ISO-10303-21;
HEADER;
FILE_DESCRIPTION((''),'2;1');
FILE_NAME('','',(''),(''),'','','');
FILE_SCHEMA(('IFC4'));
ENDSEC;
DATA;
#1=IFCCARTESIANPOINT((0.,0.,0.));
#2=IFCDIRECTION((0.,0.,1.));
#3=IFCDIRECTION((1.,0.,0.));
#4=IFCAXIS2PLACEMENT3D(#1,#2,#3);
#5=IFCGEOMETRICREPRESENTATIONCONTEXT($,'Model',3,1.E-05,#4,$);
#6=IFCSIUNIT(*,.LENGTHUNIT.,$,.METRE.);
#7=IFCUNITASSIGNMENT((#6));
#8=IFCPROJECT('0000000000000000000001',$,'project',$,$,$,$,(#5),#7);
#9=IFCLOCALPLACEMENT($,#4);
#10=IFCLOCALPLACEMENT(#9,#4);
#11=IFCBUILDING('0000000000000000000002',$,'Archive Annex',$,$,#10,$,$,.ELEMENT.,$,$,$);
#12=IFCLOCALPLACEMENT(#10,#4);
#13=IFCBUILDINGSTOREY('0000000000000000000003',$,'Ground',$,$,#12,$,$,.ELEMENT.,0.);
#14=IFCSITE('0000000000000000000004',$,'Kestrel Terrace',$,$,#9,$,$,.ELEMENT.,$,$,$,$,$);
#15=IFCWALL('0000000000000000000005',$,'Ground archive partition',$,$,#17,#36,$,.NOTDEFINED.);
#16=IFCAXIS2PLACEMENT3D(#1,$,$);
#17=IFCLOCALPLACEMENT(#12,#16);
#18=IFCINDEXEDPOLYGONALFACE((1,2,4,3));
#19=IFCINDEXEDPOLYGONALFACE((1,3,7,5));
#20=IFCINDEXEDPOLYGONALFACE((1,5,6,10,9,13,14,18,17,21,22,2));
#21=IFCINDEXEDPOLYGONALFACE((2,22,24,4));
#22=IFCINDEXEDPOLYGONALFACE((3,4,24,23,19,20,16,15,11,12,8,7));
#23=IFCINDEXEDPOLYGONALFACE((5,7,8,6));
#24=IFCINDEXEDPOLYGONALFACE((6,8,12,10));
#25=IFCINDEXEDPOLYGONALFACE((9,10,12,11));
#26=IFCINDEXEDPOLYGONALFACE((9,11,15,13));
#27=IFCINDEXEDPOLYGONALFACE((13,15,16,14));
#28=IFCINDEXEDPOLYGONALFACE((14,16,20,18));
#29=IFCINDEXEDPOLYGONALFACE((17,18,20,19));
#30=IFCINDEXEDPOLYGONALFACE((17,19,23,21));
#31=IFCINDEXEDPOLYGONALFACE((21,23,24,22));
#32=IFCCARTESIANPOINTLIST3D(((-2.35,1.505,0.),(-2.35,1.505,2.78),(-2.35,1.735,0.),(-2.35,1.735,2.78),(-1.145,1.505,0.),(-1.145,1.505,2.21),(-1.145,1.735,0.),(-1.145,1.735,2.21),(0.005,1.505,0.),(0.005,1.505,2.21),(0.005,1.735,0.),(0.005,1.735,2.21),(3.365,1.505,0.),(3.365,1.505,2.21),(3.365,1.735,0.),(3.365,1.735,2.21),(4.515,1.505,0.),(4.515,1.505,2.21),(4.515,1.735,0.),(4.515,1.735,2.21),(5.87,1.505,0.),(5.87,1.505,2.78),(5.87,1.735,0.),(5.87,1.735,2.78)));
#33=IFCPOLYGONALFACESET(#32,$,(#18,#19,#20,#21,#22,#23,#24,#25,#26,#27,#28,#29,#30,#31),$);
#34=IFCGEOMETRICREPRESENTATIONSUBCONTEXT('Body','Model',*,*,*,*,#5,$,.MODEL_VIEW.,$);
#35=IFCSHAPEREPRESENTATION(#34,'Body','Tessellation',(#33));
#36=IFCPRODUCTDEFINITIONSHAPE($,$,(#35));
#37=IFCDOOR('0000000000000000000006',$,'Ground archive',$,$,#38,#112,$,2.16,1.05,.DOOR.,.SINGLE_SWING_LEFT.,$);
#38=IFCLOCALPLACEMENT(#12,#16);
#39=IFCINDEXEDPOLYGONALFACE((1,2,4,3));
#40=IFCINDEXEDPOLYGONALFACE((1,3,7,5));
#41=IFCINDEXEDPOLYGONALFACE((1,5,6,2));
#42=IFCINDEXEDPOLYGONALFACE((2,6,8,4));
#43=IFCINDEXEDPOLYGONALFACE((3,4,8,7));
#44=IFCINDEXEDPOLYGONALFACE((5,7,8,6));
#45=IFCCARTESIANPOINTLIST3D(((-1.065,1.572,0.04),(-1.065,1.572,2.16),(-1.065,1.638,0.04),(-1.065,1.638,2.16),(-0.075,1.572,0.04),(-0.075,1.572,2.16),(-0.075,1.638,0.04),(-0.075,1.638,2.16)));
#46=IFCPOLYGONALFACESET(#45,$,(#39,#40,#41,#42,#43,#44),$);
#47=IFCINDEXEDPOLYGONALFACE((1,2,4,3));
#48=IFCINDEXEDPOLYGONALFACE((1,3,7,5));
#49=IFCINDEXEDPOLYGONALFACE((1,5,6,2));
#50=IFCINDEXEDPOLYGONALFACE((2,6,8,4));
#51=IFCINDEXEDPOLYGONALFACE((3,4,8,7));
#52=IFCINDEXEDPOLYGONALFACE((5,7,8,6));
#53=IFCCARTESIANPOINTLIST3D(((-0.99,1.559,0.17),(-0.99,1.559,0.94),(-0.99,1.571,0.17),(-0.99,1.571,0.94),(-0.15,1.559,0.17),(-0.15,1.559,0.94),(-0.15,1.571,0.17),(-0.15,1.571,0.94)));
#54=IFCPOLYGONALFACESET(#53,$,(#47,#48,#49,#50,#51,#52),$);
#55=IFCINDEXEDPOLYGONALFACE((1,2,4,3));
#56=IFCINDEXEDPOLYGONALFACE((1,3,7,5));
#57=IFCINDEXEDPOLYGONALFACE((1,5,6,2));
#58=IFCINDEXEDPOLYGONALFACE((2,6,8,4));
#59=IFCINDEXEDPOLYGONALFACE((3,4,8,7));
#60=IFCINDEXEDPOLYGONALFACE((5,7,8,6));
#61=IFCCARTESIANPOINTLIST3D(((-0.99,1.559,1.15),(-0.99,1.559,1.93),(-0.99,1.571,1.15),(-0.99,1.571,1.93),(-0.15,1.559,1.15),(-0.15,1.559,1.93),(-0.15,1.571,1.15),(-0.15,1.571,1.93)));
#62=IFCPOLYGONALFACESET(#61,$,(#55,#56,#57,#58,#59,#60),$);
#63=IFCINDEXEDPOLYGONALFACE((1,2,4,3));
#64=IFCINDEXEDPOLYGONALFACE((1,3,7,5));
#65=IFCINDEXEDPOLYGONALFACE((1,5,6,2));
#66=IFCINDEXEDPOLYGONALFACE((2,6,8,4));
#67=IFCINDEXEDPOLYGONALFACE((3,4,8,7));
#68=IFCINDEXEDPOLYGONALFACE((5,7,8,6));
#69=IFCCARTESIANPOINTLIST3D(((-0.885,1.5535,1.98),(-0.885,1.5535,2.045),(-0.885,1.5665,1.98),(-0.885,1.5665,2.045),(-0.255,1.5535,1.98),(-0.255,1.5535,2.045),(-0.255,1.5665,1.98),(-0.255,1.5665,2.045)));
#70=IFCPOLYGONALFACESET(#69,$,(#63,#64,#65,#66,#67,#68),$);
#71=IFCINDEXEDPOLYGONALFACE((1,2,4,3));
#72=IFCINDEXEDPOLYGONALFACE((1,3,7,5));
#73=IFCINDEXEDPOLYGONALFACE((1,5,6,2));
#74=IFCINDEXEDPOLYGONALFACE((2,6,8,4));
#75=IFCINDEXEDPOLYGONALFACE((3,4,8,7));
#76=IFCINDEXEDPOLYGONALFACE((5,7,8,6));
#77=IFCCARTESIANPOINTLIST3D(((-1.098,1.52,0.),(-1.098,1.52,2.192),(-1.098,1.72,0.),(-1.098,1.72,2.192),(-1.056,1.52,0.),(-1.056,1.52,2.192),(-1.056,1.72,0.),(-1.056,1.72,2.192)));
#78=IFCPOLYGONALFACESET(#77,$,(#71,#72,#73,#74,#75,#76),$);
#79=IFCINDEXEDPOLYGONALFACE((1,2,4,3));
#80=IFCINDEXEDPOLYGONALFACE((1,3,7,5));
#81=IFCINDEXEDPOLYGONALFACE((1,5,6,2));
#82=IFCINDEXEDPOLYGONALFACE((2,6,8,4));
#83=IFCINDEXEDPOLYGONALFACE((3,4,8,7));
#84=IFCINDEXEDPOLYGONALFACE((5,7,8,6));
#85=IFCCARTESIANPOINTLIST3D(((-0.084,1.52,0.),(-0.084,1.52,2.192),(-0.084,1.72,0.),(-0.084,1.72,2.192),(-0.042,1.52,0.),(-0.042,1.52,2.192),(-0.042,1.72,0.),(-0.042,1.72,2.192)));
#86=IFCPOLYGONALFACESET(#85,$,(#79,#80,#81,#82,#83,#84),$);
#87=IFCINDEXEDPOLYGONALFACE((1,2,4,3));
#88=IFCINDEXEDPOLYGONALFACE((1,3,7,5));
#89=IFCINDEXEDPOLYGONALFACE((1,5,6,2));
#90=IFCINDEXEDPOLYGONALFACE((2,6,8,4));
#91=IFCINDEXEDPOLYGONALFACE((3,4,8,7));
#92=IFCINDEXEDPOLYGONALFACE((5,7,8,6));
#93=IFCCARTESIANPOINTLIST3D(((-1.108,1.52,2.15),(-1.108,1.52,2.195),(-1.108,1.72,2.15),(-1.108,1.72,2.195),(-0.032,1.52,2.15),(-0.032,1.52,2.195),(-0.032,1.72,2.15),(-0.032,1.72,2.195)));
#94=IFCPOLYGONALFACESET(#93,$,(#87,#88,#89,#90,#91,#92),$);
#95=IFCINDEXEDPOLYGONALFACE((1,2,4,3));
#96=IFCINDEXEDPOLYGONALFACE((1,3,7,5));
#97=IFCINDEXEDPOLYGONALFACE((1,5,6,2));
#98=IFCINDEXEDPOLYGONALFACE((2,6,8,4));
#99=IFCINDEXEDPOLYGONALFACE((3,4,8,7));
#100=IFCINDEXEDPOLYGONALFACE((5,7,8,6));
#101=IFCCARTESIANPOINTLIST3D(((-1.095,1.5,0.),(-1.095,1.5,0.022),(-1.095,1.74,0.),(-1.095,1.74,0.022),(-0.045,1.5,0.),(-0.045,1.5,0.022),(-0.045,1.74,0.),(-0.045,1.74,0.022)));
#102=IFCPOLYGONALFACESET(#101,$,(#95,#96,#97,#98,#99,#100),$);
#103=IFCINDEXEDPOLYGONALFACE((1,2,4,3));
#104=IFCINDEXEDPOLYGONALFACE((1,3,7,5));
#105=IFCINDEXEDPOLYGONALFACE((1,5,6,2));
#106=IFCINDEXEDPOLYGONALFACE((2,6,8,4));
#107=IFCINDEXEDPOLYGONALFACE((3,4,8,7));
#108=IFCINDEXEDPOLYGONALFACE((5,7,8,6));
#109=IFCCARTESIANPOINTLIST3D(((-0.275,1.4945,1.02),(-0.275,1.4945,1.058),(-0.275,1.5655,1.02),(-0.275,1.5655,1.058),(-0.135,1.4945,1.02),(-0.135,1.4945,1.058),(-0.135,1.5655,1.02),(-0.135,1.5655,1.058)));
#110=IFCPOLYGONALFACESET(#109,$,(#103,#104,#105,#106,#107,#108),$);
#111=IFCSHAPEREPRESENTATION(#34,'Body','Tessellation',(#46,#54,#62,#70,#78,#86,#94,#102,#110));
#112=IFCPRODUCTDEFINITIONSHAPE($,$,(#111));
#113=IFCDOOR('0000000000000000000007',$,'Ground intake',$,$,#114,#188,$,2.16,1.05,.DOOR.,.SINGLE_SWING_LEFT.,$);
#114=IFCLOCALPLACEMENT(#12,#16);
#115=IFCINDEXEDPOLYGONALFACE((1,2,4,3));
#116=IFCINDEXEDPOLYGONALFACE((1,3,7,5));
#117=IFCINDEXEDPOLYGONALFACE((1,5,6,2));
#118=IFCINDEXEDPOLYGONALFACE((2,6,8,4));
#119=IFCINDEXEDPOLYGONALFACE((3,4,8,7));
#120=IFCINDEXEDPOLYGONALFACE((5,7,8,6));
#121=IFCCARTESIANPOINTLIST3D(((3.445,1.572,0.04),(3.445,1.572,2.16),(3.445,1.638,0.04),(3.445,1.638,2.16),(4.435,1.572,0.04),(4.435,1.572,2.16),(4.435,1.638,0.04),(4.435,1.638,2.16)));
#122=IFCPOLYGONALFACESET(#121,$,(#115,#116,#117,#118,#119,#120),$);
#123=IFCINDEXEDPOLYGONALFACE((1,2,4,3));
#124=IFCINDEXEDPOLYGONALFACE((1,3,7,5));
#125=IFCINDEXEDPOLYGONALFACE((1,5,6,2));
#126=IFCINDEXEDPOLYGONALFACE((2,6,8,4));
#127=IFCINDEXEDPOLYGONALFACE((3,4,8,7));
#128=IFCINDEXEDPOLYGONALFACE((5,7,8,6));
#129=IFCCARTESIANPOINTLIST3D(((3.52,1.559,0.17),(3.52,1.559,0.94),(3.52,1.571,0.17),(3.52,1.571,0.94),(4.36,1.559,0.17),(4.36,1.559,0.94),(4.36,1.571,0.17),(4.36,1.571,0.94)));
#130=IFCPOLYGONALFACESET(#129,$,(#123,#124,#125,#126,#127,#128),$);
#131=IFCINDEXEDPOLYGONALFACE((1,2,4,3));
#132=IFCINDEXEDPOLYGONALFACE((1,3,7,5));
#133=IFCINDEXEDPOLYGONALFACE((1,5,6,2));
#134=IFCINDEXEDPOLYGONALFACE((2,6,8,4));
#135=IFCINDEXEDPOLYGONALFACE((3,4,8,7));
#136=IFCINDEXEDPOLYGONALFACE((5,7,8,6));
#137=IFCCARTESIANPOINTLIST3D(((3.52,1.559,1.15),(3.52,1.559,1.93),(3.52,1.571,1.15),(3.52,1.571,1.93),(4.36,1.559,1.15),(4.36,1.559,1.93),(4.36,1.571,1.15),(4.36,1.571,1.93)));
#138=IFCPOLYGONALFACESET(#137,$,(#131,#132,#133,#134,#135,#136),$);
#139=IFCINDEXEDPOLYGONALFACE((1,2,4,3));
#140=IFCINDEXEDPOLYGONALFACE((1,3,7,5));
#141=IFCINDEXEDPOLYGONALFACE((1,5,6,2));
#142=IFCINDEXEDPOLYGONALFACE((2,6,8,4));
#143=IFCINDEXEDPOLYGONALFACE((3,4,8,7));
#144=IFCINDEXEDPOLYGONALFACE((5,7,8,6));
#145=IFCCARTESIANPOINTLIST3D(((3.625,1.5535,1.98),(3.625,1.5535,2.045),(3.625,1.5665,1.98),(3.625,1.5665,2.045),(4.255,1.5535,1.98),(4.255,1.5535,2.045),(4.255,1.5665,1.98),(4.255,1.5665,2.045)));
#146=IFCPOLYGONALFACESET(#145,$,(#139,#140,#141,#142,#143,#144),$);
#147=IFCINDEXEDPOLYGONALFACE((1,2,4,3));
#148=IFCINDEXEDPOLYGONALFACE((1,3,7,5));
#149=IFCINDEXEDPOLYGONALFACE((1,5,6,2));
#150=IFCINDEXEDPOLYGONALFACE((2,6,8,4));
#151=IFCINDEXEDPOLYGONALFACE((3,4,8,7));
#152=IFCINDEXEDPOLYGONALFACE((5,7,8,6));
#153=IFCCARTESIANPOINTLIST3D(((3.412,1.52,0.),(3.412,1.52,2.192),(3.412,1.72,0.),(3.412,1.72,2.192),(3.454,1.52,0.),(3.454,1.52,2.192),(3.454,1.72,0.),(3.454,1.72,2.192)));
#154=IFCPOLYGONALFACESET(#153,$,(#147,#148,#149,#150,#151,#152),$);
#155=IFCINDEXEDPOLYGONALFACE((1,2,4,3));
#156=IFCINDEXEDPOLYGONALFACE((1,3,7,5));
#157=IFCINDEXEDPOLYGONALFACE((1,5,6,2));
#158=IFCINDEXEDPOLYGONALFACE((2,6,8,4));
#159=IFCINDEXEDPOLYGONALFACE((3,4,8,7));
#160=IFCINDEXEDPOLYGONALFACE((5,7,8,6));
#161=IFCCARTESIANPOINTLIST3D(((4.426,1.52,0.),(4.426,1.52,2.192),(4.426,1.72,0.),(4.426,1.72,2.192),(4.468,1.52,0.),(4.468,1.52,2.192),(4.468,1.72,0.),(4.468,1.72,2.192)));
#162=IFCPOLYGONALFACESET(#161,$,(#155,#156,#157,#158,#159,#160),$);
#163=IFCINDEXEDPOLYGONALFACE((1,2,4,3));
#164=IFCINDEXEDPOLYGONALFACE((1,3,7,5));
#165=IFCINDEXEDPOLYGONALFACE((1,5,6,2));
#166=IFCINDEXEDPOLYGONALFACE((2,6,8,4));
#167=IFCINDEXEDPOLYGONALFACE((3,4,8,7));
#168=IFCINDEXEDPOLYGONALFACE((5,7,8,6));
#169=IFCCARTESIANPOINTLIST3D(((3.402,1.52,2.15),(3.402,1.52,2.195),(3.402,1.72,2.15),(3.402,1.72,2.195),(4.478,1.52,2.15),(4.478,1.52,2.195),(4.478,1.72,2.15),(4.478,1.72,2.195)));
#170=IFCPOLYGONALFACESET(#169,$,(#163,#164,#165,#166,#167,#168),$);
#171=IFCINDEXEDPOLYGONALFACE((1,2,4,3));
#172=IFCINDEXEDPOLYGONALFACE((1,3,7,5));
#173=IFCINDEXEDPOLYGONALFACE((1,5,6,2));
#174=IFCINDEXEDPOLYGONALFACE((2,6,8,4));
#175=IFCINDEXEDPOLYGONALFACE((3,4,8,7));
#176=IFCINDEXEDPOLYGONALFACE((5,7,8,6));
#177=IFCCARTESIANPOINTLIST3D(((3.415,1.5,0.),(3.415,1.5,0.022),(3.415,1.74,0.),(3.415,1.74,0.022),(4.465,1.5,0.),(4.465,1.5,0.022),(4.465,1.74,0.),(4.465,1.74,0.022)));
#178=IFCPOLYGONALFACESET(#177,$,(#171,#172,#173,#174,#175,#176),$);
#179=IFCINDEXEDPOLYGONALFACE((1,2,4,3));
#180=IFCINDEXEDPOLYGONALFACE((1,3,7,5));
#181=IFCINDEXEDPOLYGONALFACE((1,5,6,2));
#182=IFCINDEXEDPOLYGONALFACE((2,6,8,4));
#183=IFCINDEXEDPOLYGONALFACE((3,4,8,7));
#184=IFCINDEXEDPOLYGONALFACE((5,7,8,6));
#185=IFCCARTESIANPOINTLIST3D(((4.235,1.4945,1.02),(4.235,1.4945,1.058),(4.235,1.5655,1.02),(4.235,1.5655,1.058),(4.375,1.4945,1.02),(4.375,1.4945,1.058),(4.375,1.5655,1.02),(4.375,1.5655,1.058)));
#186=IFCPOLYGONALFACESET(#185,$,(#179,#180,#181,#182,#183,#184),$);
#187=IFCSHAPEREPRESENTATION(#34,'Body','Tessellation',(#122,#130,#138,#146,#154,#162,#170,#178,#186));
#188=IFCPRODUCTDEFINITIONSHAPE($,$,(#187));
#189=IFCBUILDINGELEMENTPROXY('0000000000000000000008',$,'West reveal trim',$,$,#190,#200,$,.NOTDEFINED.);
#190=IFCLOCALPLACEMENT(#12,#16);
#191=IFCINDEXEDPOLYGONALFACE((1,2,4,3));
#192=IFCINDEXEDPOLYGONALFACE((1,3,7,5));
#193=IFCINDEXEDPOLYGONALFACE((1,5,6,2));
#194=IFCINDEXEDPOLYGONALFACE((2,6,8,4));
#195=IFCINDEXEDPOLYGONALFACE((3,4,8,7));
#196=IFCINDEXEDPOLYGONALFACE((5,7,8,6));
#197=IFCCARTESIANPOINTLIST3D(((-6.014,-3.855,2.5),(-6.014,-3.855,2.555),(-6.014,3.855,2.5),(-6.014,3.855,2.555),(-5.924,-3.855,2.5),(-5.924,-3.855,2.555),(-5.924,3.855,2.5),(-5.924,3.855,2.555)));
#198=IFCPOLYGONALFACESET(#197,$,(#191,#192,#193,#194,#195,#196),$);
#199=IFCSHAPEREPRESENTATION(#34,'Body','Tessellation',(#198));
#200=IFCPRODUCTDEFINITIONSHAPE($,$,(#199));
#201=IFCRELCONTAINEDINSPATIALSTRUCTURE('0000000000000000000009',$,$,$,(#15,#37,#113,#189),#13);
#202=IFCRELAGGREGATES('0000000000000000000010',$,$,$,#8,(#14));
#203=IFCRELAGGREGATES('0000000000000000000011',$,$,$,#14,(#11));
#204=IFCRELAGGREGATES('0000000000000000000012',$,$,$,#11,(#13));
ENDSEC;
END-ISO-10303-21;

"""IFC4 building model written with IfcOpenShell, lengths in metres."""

from ifc_helpers import new_model, si_unit, frame, origin_with_axes, origin_2d, place, context, subcontext, project, spatial, rectangle, extrude, element, fill, save


model = new_model("IFC4")

# Units and contexts
model_context = context("Model", 3, precision=1e-05, world=origin_with_axes())
body_context = subcontext(model_context, "Body", "Model", "MODEL_VIEW")
ifc_project = project(units=[si_unit("LENGTHUNIT", "METRE")], contexts=[model_context])

# Site, building, storey
site_placement = place(None, origin_with_axes())
site = spatial("IfcSite", under=ifc_project, at=site_placement, Name="Kestrel Terrace", CompositionType="ELEMENT")
building_placement = place(site_placement, origin_with_axes())
building = spatial("IfcBuilding", under=site, at=building_placement, Name="Archive Annex", CompositionType="ELEMENT")
storey_placement = place(building_placement, origin_with_axes())
storey = spatial("IfcBuildingStorey", under=building, at=storey_placement, Name="Ground", CompositionType="ELEMENT", Elevation=0.0)

# Wall, openings, doors
wall_1_placement = place(storey_placement, frame((1.76, 1.62, 0.0), z_axis=(0.0, 0.0, 1.0), x_axis=(1.0, 0.0, 0.0)))
wall_1 = element("IfcWall", 1, at=wall_1_placement, inside=storey, Name="Ground archive partition", PredefinedType="NOTDEFINED", context=body_context, shape_type="SweptSolid", body=[
    extrude(rectangle(XDim=8.22, YDim=0.23, at=origin_2d()), origin_with_axes(), (0.0, 0.0, 1.0), 2.78),
])
opening_1_placement = place(wall_1_placement, frame((-2.33, 0.0, 0.0), z_axis=(0.0, 0.0, 1.0), x_axis=(1.0, 0.0, 0.0)))
opening_1 = element("IfcOpeningElement", 2, at=opening_1_placement, cuts=wall_1, PredefinedType="OPENING", context=body_context, shape_type="SweptSolid", body=[
    extrude(rectangle(XDim=1.15, YDim=0.58, at=origin_2d()), origin_with_axes(), (0.0, 0.0, 1.0), 2.21),
])
opening_2_placement = place(wall_1_placement, frame((2.18, 0.0, 0.0), z_axis=(0.0, 0.0, 1.0), x_axis=(1.0, 0.0, 0.0)))
opening_2 = element("IfcOpeningElement", 3, at=opening_2_placement, cuts=wall_1, PredefinedType="OPENING", context=body_context, shape_type="SweptSolid", body=[
    extrude(rectangle(XDim=1.15, YDim=0.58, at=origin_2d()), origin_with_axes(), (0.0, 0.0, 1.0), 2.21),
])
door_1_placement = place(opening_1_placement, origin_with_axes())
door_1 = element("IfcDoor", 4, at=door_1_placement, inside=storey, Name="Ground archive", OperationType="SINGLE_SWING_LEFT", OverallHeight=2.16, OverallWidth=1.05, PredefinedType="DOOR", context=body_context, shape_type="SweptSolid", body=[
    extrude(rectangle(XDim=0.99, YDim=0.066, at=origin_2d()), frame((0.0, -0.015, 0.04), z_axis=(0.0, 0.0, 1.0), x_axis=(1.0, 0.0, 0.0)), (0.0, 0.0, 1.0), 2.12),
    extrude(rectangle(XDim=0.84, YDim=0.012, at=origin_2d()), frame((0.0, -0.055, 0.17), z_axis=(0.0, 0.0, 1.0), x_axis=(1.0, 0.0, 0.0)), (0.0, 0.0, 1.0), 0.77),
    extrude(rectangle(XDim=0.84, YDim=0.012, at=origin_2d()), frame((0.0, -0.055, 1.15), z_axis=(0.0, 0.0, 1.0), x_axis=(1.0, 0.0, 0.0)), (0.0, 0.0, 1.0), 0.78),
    extrude(rectangle(XDim=0.63, YDim=0.013, at=origin_2d()), frame((0.0, -0.06, 1.98), z_axis=(0.0, 0.0, 1.0), x_axis=(1.0, 0.0, 0.0)), (0.0, 0.0, 1.0), 0.065),
    extrude(rectangle(XDim=0.042, YDim=0.2, at=origin_2d()), frame((-0.507, 0.0, 0.0), z_axis=(0.0, 0.0, 1.0), x_axis=(1.0, 0.0, 0.0)), (0.0, 0.0, 1.0), 2.192),
    extrude(rectangle(XDim=0.042, YDim=0.2, at=origin_2d()), frame((0.507, 0.0, 0.0), z_axis=(0.0, 0.0, 1.0), x_axis=(1.0, 0.0, 0.0)), (0.0, 0.0, 1.0), 2.192),
    extrude(rectangle(XDim=1.076, YDim=0.2, at=origin_2d()), frame((0.0, 0.0, 2.15), z_axis=(0.0, 0.0, 1.0), x_axis=(1.0, 0.0, 0.0)), (0.0, 0.0, 1.0), 0.045),
    extrude(rectangle(XDim=1.05, YDim=0.24, at=origin_2d()), origin_with_axes(), (0.0, 0.0, 1.0), 0.022),
    extrude(rectangle(XDim=0.14, YDim=0.071, at=origin_2d()), frame((0.365, -0.09, 1.02), z_axis=(0.0, 0.0, 1.0), x_axis=(1.0, 0.0, 0.0)), (0.0, 0.0, 1.0), 0.038),
])
fill(opening_1, door_1)
door_2_placement = place(opening_2_placement, origin_with_axes())
door_2 = element("IfcDoor", 5, at=door_2_placement, inside=storey, Name="Ground intake", OperationType="SINGLE_SWING_LEFT", OverallHeight=2.16, OverallWidth=1.05, PredefinedType="DOOR", context=body_context, shape_type="SweptSolid", body=[
    extrude(rectangle(XDim=0.99, YDim=0.066, at=origin_2d()), frame((0.0, -0.015, 0.04), z_axis=(0.0, 0.0, 1.0), x_axis=(1.0, 0.0, 0.0)), (0.0, 0.0, 1.0), 2.12),
    extrude(rectangle(XDim=0.84, YDim=0.012, at=origin_2d()), frame((0.0, -0.055, 0.17), z_axis=(0.0, 0.0, 1.0), x_axis=(1.0, 0.0, 0.0)), (0.0, 0.0, 1.0), 0.77),
    extrude(rectangle(XDim=0.84, YDim=0.012, at=origin_2d()), frame((0.0, -0.055, 1.15), z_axis=(0.0, 0.0, 1.0), x_axis=(1.0, 0.0, 0.0)), (0.0, 0.0, 1.0), 0.78),
    extrude(rectangle(XDim=0.63, YDim=0.013, at=origin_2d()), frame((0.0, -0.06, 1.98), z_axis=(0.0, 0.0, 1.0), x_axis=(1.0, 0.0, 0.0)), (0.0, 0.0, 1.0), 0.065),
    extrude(rectangle(XDim=0.042, YDim=0.2, at=origin_2d()), frame((-0.507, 0.0, 0.0), z_axis=(0.0, 0.0, 1.0), x_axis=(1.0, 0.0, 0.0)), (0.0, 0.0, 1.0), 2.192),
    extrude(rectangle(XDim=0.042, YDim=0.2, at=origin_2d()), frame((0.507, 0.0, 0.0), z_axis=(0.0, 0.0, 1.0), x_axis=(1.0, 0.0, 0.0)), (0.0, 0.0, 1.0), 2.192),
    extrude(rectangle(XDim=1.076, YDim=0.2, at=origin_2d()), frame((0.0, 0.0, 2.15), z_axis=(0.0, 0.0, 1.0), x_axis=(1.0, 0.0, 0.0)), (0.0, 0.0, 1.0), 0.045),
    extrude(rectangle(XDim=1.05, YDim=0.24, at=origin_2d()), origin_with_axes(), (0.0, 0.0, 1.0), 0.022),
    extrude(rectangle(XDim=0.14, YDim=0.071, at=origin_2d()), frame((0.365, -0.09, 1.02), z_axis=(0.0, 0.0, 1.0), x_axis=(1.0, 0.0, 0.0)), (0.0, 0.0, 1.0), 0.038),
])
fill(opening_2, door_2)

# Building element proxy
proxy_1_placement = place(storey_placement, origin_with_axes())
element("IfcBuildingElementProxy", 6, at=proxy_1_placement, inside=storey, Name="West reveal trim", PredefinedType="NOTDEFINED", context=body_context, shape_type="SweptSolid", body=[
    extrude(rectangle(XDim=0.09, YDim=7.71, at=origin_2d()), frame((-5.969, 0.0, 2.5), z_axis=(0.0, 0.0, 1.0), x_axis=(1.0, 0.0, 0.0)), (0.0, 0.0, 1.0), 0.055),
])

save(model, "model.ifc")
